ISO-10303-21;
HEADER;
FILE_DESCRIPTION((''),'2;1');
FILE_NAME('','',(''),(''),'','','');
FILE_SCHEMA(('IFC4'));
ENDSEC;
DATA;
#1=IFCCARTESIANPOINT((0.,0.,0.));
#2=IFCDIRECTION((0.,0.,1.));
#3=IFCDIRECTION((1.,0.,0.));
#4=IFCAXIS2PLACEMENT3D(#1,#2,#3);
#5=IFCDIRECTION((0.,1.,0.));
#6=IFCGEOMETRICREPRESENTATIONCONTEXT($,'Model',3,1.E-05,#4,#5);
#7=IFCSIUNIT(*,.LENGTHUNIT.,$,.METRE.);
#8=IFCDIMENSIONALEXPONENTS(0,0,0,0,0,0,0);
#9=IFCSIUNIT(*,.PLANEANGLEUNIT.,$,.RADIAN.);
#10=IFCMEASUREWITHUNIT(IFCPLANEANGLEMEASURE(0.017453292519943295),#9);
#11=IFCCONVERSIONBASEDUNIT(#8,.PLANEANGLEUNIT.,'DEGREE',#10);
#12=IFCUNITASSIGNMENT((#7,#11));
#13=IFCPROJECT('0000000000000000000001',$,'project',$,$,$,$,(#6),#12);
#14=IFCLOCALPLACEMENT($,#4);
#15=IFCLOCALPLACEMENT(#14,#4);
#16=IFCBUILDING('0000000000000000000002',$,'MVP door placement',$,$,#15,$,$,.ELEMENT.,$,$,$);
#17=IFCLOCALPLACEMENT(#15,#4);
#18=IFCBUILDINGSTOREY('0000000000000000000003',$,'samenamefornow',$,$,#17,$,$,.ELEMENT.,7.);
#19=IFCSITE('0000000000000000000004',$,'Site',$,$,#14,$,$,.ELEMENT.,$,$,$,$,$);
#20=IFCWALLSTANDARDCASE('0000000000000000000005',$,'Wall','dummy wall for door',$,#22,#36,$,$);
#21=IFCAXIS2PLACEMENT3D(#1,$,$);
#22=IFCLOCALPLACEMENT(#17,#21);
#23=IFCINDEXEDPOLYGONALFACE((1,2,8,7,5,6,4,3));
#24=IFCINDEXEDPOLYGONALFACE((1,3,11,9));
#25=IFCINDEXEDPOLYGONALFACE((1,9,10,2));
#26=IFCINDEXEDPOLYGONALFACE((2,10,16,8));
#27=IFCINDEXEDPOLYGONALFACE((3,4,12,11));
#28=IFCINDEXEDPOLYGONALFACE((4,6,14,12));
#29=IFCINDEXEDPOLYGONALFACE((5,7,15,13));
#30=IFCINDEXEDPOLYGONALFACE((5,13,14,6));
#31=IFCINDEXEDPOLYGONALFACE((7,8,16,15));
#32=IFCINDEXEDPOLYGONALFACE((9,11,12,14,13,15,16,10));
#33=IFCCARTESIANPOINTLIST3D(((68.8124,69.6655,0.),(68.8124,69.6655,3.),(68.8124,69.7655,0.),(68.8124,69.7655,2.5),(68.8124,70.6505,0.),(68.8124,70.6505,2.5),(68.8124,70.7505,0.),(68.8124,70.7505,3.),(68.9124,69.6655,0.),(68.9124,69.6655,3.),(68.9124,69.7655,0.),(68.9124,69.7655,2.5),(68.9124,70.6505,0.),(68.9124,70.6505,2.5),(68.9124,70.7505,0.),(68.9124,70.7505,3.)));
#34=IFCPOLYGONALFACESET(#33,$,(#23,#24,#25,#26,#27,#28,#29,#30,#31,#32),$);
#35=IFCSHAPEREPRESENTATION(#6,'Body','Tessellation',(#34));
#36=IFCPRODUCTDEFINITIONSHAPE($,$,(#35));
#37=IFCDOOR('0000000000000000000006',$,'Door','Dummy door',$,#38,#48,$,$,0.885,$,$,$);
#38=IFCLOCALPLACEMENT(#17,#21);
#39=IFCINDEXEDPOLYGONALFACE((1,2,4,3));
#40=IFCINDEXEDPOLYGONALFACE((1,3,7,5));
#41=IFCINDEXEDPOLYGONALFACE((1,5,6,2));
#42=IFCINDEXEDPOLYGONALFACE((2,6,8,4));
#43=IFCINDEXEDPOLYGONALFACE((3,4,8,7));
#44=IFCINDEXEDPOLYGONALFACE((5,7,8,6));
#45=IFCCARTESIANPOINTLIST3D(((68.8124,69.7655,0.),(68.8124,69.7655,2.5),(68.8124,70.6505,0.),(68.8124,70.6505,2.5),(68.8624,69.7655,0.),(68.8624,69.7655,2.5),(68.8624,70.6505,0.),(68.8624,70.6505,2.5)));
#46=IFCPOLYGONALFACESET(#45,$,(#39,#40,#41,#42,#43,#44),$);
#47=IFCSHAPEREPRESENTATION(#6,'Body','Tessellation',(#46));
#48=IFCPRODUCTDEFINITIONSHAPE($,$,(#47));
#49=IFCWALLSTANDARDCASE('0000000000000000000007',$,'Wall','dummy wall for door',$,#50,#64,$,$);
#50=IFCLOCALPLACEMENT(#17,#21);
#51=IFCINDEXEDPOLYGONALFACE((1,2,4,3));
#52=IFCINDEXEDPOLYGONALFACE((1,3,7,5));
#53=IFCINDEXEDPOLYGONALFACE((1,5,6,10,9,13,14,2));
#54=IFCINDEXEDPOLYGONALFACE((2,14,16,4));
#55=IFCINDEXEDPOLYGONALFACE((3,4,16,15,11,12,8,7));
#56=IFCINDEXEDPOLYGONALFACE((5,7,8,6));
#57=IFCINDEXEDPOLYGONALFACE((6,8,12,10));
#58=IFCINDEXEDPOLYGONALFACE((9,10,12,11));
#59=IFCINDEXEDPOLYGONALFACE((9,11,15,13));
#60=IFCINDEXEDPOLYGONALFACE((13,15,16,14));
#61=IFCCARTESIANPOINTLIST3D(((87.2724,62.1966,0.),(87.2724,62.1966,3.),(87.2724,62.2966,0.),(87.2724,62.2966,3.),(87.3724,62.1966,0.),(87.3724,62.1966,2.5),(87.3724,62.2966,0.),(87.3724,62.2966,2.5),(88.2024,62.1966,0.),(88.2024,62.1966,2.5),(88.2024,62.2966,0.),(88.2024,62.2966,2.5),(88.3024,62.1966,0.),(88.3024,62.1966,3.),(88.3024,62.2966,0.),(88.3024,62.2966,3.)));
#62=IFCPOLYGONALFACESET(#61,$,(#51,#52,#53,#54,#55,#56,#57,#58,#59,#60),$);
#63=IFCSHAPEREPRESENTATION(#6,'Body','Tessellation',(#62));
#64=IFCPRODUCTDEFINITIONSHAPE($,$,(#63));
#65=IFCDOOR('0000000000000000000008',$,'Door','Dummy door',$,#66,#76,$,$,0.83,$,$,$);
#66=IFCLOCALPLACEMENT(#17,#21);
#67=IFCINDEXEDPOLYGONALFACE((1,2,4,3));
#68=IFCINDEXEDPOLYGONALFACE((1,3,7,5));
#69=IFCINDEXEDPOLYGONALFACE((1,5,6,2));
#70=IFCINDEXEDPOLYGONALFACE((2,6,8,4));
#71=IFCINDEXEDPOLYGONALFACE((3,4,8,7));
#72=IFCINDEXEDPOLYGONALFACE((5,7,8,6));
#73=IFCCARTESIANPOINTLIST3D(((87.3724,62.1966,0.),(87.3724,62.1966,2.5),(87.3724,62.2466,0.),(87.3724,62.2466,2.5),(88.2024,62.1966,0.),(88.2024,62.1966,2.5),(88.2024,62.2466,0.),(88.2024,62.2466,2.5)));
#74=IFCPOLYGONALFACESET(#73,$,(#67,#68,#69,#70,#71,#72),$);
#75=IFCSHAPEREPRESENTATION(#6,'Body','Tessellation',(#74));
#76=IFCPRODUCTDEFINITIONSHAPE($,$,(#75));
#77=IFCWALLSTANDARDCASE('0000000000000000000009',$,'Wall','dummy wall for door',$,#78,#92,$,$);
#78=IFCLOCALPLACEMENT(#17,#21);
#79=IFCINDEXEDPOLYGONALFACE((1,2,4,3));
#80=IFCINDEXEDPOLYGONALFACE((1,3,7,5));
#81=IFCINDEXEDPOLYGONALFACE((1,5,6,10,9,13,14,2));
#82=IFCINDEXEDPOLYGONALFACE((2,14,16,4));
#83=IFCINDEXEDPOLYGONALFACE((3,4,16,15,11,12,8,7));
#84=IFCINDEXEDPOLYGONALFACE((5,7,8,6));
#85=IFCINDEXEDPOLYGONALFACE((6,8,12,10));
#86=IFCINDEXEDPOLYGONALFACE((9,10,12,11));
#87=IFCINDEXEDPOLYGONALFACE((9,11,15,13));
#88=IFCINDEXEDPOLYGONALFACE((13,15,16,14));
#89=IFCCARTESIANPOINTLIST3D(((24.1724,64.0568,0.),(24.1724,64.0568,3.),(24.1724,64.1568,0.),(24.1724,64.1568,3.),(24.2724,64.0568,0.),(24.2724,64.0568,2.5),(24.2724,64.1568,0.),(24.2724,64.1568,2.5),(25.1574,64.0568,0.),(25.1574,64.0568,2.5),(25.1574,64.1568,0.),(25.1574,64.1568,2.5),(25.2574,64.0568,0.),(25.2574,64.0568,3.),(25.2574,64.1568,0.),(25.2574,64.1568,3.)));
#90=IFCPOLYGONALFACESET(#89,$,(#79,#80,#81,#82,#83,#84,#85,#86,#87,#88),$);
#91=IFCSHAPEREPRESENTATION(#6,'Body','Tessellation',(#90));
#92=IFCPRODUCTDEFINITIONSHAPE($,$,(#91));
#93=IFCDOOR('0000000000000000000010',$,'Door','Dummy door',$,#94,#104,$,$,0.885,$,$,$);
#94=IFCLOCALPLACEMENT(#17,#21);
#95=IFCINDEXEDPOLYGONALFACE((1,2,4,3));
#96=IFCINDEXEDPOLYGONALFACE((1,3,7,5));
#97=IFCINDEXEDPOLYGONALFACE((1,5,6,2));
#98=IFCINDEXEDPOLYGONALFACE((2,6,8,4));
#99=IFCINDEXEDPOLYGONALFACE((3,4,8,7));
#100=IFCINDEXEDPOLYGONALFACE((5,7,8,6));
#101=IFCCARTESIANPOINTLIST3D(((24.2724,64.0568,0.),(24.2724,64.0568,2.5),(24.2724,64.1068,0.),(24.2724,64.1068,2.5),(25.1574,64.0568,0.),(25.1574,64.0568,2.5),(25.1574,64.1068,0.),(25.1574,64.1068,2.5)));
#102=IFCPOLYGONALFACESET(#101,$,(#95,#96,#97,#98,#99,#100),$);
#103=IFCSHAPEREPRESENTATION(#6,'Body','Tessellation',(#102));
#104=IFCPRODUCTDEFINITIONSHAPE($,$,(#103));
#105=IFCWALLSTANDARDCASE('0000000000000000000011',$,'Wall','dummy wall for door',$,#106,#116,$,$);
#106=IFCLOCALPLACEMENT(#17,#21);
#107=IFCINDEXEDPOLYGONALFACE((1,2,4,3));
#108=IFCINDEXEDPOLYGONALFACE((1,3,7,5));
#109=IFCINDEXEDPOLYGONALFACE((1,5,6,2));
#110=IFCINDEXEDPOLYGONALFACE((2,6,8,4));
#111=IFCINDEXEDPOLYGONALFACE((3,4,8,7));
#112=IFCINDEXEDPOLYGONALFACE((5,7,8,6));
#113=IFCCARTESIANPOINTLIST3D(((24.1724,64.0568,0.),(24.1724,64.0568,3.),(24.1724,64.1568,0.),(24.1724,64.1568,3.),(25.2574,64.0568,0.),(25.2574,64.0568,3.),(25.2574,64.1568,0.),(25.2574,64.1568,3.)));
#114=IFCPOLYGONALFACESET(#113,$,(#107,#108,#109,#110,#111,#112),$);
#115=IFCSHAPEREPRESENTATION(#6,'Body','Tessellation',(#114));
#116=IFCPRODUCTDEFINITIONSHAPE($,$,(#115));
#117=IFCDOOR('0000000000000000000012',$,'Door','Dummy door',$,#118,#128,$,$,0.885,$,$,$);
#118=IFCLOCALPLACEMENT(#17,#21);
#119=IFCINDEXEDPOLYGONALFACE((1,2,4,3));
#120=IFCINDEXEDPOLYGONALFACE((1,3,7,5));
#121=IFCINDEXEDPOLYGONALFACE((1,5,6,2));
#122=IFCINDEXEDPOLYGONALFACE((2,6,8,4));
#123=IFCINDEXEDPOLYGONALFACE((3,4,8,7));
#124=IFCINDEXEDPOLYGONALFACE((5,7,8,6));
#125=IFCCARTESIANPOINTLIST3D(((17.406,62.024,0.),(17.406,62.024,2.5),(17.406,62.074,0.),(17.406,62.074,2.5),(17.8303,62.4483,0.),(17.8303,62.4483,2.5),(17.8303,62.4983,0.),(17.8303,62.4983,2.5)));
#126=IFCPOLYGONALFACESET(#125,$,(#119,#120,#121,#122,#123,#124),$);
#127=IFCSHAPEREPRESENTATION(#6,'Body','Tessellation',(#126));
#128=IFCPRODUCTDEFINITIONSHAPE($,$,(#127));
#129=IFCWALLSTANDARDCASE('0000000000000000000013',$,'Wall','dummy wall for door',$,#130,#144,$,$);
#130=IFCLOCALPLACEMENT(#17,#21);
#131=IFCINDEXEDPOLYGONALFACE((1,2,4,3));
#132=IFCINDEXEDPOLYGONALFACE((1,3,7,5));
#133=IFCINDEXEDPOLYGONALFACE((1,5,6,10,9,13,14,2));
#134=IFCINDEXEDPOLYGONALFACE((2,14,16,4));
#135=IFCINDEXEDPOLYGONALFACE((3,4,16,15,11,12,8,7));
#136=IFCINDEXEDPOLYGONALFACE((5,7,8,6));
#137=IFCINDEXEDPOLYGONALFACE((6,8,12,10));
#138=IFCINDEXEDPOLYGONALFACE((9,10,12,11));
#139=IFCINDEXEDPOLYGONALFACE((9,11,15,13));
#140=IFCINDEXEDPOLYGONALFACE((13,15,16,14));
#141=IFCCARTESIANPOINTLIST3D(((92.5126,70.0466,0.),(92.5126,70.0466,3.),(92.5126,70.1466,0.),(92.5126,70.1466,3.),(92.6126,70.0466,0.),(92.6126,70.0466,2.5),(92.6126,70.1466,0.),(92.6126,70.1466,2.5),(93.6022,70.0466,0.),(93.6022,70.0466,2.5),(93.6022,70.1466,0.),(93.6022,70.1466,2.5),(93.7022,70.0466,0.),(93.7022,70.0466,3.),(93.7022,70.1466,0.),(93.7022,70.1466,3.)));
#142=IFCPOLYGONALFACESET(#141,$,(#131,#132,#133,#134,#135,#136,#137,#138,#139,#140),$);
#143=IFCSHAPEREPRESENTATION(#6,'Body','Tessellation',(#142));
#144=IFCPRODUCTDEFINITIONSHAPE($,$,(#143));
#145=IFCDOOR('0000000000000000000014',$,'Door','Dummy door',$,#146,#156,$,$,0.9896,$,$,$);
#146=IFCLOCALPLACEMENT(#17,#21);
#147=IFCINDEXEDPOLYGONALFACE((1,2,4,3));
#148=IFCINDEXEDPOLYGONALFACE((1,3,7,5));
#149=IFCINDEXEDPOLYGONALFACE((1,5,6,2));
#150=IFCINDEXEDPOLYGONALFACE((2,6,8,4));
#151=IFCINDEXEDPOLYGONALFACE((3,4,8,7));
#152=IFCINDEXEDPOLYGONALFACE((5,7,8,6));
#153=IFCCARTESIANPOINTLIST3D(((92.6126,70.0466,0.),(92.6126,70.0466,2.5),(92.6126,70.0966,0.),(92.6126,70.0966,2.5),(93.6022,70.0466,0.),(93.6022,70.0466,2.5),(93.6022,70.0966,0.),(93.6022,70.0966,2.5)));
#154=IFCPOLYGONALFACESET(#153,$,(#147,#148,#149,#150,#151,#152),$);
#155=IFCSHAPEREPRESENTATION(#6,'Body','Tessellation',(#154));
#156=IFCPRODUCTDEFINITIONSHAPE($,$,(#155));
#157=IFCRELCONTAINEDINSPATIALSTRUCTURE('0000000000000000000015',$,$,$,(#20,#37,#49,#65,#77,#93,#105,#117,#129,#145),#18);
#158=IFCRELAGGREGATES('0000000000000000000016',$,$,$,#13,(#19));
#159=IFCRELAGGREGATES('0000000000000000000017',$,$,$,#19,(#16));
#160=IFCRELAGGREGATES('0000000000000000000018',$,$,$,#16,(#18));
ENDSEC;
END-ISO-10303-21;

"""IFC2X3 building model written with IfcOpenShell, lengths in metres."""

from ifc_helpers import new_model, entity, si_unit, converted_unit, direction, origin_with_axes, place, context, project, spatial, polyline, outline, extrude, element, fill, save


model = new_model("IFC2X3")

# Units and contexts
model_context = context("Model", 3, precision=1e-05, world=origin_with_axes(), true_north=direction((0.0, 1.0, 0.0)))
ifc_project = project(units=[si_unit("LENGTHUNIT", "METRE"), converted_unit("PLANEANGLEUNIT", "DEGREE", entity("IfcPlaneAngleMeasure", 0.017453292519943295), si_unit("PLANEANGLEUNIT", "RADIAN"), dimensions=[0, 0, 0, 0, 0, 0, 0])], contexts=[model_context])

# Site, building, storey
site_placement = place(None, origin_with_axes())
site = spatial("IfcSite", under=ifc_project, at=site_placement, Name="Site", CompositionType="ELEMENT")
building_placement = place(site_placement, origin_with_axes())
building = spatial("IfcBuilding", under=site, at=building_placement, Name="MVP door placement", CompositionType="ELEMENT")
storey_placement = place(building_placement, origin_with_axes())
storey = spatial("IfcBuildingStorey", under=building, at=storey_placement, Name="samenamefornow", CompositionType="ELEMENT", Elevation=7.0)

# Walls, openings, doors
wall_1_placement = place(storey_placement, origin_with_axes())
wall_1 = element("IfcWallStandardCase", 1, at=wall_1_placement, inside=storey, Name="Wall", Description="dummy wall for door", context=model_context, shape_type="SweptSolid", body=[
    extrude(outline(polyline([(68.8124, 69.6655, 0.0), (68.8124, 70.7505, 0.0), (68.9124, 70.7505, 0.0), (68.9124, 69.6655, 0.0), (68.8124, 69.6655, 0.0)])), origin_with_axes(), (0.0, 0.0, 1.0), 3.0),
])
opening_1_placement = place(wall_1_placement, origin_with_axes())
opening_1 = element("IfcOpeningElement", 2, at=opening_1_placement, cuts=wall_1, context=model_context, shape_type="SweptSolid", body=[
    extrude(outline(polyline([(68.8124, 69.7655, 0.0), (68.8124, 70.6505, 0.0), (68.9124, 70.6505, 0.0), (68.9124, 69.7655, 0.0), (68.8124, 69.7655, 0.0)])), origin_with_axes(), (0.0, 0.0, 1.0), 2.5),
])
door_1_placement = place(opening_1_placement, origin_with_axes())
door_1 = element("IfcDoor", 3, at=door_1_placement, inside=storey, Name="Door", Description="Dummy door", OverallWidth=0.885, context=model_context, shape_type="SweptSolid", body=[
    extrude(outline(polyline([(68.8124, 69.7655, 0.0), (68.8124, 70.6505, 0.0), (68.8624, 70.6505, 0.0), (68.8624, 69.7655, 0.0), (68.8124, 69.7655, 0.0)])), origin_with_axes(), (0.0, 0.0, 1.0), 2.5),
])
fill(opening_1, door_1)
wall_2_placement = place(storey_placement, origin_with_axes())
wall_2 = element("IfcWallStandardCase", 4, at=wall_2_placement, inside=storey, Name="Wall", Description="dummy wall for door", context=model_context, shape_type="SweptSolid", body=[
    extrude(outline(polyline([(87.2724, 62.1966, 0.0), (88.3024, 62.1966, 0.0), (88.3024, 62.2966, 0.0), (87.2724, 62.2966, 0.0), (87.2724, 62.1966, 0.0)])), origin_with_axes(), (0.0, 0.0, 1.0), 3.0),
])
opening_2_placement = place(wall_2_placement, origin_with_axes())
opening_2 = element("IfcOpeningElement", 5, at=opening_2_placement, cuts=wall_2, context=model_context, shape_type="SweptSolid", body=[
    extrude(outline(polyline([(87.3724, 62.1966, 0.0), (88.2024, 62.1966, 0.0), (88.2024, 62.2966, 0.0), (87.3724, 62.2966, 0.0), (87.3724, 62.1966, 0.0)])), origin_with_axes(), (0.0, 0.0, 1.0), 2.5),
])
door_2_placement = place(opening_2_placement, origin_with_axes())
door_2 = element("IfcDoor", 6, at=door_2_placement, inside=storey, Name="Door", Description="Dummy door", OverallWidth=0.83, context=model_context, shape_type="SweptSolid", body=[
    extrude(outline(polyline([(87.3724, 62.1966, 0.0), (88.2024, 62.1966, 0.0), (88.2024, 62.2466, 0.0), (87.3724, 62.2466, 0.0), (87.3724, 62.1966, 0.0)])), origin_with_axes(), (0.0, 0.0, 1.0), 2.5),
])
fill(opening_2, door_2)
wall_3_placement = place(storey_placement, origin_with_axes())
wall_3 = element("IfcWallStandardCase", 7, at=wall_3_placement, inside=storey, Name="Wall", Description="dummy wall for door", context=model_context, shape_type="SweptSolid", body=[
    extrude(outline(polyline([(25.2574, 64.0568, 0.0), (24.1724, 64.0568, 0.0), (24.1724, 64.1568, 0.0), (25.2574, 64.1568, 0.0), (25.2574, 64.0568, 0.0)])), origin_with_axes(), (0.0, 0.0, 1.0), 3.0),
])
opening_3_placement = place(wall_3_placement, origin_with_axes())
opening_3 = element("IfcOpeningElement", 8, at=opening_3_placement, cuts=wall_3, context=model_context, shape_type="SweptSolid", body=[
    extrude(outline(polyline([(25.1574, 64.0568, 0.0), (24.2724, 64.0568, 0.0), (24.2724, 64.1568, 0.0), (25.1574, 64.1568, 0.0), (25.1574, 64.0568, 0.0)])), origin_with_axes(), (0.0, 0.0, 1.0), 2.5),
])
door_3_placement = place(opening_3_placement, origin_with_axes())
door_3 = element("IfcDoor", 9, at=door_3_placement, inside=storey, Name="Door", Description="Dummy door", OverallWidth=0.885, context=model_context, shape_type="SweptSolid", body=[
    extrude(outline(polyline([(25.1574, 64.0568, 0.0), (24.2724, 64.0568, 0.0), (24.2724, 64.1068, 0.0), (25.1574, 64.1068, 0.0), (25.1574, 64.0568, 0.0)])), origin_with_axes(), (0.0, 0.0, 1.0), 2.5),
])
fill(opening_3, door_3)
wall_4_placement = place(storey_placement, origin_with_axes())
wall_4 = element("IfcWallStandardCase", 10, at=wall_4_placement, inside=storey, Name="Wall", Description="dummy wall for door", context=model_context, shape_type="SweptSolid", body=[
    extrude(outline(polyline([(25.2574, 64.0568, 0.0), (24.1724, 64.0568, 0.0), (24.1724, 64.1568, 0.0), (25.2574, 64.1568, 0.0), (25.2574, 64.0568, 0.0)])), origin_with_axes(), (0.0, 0.0, 1.0), 3.0),
])
opening_4_placement = place(wall_4_placement, origin_with_axes())
opening_4 = element("IfcOpeningElement", 11, at=opening_4_placement, cuts=wall_4, context=model_context, shape_type="SweptSolid", body=[
    extrude(outline(polyline([(17.406, 62.024, 0.0), (17.8303, 62.4483, 0.0), (17.8303, 62.5483, 0.0), (17.406, 62.124, 0.0), (17.406, 62.024, 0.0)])), origin_with_axes(), (0.0, 0.0, 1.0), 2.5),
])
door_4_placement = place(opening_4_placement, origin_with_axes())
door_4 = element("IfcDoor", 12, at=door_4_placement, inside=storey, Name="Door", Description="Dummy door", OverallWidth=0.885, context=model_context, shape_type="SweptSolid", body=[
    extrude(outline(polyline([(17.406, 62.024, 0.0), (17.8303, 62.4483, 0.0), (17.8303, 62.4983, 0.0), (17.406, 62.074, 0.0), (17.406, 62.024, 0.0)])), origin_with_axes(), (0.0, 0.0, 1.0), 2.5),
])
fill(opening_4, door_4)
wall_5_placement = place(storey_placement, origin_with_axes())
wall_5 = element("IfcWallStandardCase", 13, at=wall_5_placement, inside=storey, Name="Wall", Description="dummy wall for door", context=model_context, shape_type="SweptSolid", body=[
    extrude(outline(polyline([(92.5126, 70.0466, 0.0), (93.7022, 70.0466, 0.0), (93.7022, 70.1466, 0.0), (92.5126, 70.1466, 0.0), (92.5126, 70.0466, 0.0)])), origin_with_axes(), (0.0, 0.0, 1.0), 3.0),
])
opening_5_placement = place(wall_5_placement, origin_with_axes())
opening_5 = element("IfcOpeningElement", 14, at=opening_5_placement, cuts=wall_5, context=model_context, shape_type="SweptSolid", body=[
    extrude(outline(polyline([(92.6126, 70.0466, 0.0), (93.6022, 70.0466, 0.0), (93.6022, 70.1466, 0.0), (92.6126, 70.1466, 0.0), (92.6126, 70.0466, 0.0)])), origin_with_axes(), (0.0, 0.0, 1.0), 2.5),
])
door_5_placement = place(opening_5_placement, origin_with_axes())
door_5 = element("IfcDoor", 15, at=door_5_placement, inside=storey, Name="Door", Description="Dummy door", OverallWidth=0.9896, context=model_context, shape_type="SweptSolid", body=[
    extrude(outline(polyline([(92.6126, 70.0466, 0.0), (93.6022, 70.0466, 0.0), (93.6022, 70.0966, 0.0), (92.6126, 70.0966, 0.0), (92.6126, 70.0466, 0.0)])), origin_with_axes(), (0.0, 0.0, 1.0), 2.5),
])
fill(opening_5, door_5)

save(model, "model.ifc")
